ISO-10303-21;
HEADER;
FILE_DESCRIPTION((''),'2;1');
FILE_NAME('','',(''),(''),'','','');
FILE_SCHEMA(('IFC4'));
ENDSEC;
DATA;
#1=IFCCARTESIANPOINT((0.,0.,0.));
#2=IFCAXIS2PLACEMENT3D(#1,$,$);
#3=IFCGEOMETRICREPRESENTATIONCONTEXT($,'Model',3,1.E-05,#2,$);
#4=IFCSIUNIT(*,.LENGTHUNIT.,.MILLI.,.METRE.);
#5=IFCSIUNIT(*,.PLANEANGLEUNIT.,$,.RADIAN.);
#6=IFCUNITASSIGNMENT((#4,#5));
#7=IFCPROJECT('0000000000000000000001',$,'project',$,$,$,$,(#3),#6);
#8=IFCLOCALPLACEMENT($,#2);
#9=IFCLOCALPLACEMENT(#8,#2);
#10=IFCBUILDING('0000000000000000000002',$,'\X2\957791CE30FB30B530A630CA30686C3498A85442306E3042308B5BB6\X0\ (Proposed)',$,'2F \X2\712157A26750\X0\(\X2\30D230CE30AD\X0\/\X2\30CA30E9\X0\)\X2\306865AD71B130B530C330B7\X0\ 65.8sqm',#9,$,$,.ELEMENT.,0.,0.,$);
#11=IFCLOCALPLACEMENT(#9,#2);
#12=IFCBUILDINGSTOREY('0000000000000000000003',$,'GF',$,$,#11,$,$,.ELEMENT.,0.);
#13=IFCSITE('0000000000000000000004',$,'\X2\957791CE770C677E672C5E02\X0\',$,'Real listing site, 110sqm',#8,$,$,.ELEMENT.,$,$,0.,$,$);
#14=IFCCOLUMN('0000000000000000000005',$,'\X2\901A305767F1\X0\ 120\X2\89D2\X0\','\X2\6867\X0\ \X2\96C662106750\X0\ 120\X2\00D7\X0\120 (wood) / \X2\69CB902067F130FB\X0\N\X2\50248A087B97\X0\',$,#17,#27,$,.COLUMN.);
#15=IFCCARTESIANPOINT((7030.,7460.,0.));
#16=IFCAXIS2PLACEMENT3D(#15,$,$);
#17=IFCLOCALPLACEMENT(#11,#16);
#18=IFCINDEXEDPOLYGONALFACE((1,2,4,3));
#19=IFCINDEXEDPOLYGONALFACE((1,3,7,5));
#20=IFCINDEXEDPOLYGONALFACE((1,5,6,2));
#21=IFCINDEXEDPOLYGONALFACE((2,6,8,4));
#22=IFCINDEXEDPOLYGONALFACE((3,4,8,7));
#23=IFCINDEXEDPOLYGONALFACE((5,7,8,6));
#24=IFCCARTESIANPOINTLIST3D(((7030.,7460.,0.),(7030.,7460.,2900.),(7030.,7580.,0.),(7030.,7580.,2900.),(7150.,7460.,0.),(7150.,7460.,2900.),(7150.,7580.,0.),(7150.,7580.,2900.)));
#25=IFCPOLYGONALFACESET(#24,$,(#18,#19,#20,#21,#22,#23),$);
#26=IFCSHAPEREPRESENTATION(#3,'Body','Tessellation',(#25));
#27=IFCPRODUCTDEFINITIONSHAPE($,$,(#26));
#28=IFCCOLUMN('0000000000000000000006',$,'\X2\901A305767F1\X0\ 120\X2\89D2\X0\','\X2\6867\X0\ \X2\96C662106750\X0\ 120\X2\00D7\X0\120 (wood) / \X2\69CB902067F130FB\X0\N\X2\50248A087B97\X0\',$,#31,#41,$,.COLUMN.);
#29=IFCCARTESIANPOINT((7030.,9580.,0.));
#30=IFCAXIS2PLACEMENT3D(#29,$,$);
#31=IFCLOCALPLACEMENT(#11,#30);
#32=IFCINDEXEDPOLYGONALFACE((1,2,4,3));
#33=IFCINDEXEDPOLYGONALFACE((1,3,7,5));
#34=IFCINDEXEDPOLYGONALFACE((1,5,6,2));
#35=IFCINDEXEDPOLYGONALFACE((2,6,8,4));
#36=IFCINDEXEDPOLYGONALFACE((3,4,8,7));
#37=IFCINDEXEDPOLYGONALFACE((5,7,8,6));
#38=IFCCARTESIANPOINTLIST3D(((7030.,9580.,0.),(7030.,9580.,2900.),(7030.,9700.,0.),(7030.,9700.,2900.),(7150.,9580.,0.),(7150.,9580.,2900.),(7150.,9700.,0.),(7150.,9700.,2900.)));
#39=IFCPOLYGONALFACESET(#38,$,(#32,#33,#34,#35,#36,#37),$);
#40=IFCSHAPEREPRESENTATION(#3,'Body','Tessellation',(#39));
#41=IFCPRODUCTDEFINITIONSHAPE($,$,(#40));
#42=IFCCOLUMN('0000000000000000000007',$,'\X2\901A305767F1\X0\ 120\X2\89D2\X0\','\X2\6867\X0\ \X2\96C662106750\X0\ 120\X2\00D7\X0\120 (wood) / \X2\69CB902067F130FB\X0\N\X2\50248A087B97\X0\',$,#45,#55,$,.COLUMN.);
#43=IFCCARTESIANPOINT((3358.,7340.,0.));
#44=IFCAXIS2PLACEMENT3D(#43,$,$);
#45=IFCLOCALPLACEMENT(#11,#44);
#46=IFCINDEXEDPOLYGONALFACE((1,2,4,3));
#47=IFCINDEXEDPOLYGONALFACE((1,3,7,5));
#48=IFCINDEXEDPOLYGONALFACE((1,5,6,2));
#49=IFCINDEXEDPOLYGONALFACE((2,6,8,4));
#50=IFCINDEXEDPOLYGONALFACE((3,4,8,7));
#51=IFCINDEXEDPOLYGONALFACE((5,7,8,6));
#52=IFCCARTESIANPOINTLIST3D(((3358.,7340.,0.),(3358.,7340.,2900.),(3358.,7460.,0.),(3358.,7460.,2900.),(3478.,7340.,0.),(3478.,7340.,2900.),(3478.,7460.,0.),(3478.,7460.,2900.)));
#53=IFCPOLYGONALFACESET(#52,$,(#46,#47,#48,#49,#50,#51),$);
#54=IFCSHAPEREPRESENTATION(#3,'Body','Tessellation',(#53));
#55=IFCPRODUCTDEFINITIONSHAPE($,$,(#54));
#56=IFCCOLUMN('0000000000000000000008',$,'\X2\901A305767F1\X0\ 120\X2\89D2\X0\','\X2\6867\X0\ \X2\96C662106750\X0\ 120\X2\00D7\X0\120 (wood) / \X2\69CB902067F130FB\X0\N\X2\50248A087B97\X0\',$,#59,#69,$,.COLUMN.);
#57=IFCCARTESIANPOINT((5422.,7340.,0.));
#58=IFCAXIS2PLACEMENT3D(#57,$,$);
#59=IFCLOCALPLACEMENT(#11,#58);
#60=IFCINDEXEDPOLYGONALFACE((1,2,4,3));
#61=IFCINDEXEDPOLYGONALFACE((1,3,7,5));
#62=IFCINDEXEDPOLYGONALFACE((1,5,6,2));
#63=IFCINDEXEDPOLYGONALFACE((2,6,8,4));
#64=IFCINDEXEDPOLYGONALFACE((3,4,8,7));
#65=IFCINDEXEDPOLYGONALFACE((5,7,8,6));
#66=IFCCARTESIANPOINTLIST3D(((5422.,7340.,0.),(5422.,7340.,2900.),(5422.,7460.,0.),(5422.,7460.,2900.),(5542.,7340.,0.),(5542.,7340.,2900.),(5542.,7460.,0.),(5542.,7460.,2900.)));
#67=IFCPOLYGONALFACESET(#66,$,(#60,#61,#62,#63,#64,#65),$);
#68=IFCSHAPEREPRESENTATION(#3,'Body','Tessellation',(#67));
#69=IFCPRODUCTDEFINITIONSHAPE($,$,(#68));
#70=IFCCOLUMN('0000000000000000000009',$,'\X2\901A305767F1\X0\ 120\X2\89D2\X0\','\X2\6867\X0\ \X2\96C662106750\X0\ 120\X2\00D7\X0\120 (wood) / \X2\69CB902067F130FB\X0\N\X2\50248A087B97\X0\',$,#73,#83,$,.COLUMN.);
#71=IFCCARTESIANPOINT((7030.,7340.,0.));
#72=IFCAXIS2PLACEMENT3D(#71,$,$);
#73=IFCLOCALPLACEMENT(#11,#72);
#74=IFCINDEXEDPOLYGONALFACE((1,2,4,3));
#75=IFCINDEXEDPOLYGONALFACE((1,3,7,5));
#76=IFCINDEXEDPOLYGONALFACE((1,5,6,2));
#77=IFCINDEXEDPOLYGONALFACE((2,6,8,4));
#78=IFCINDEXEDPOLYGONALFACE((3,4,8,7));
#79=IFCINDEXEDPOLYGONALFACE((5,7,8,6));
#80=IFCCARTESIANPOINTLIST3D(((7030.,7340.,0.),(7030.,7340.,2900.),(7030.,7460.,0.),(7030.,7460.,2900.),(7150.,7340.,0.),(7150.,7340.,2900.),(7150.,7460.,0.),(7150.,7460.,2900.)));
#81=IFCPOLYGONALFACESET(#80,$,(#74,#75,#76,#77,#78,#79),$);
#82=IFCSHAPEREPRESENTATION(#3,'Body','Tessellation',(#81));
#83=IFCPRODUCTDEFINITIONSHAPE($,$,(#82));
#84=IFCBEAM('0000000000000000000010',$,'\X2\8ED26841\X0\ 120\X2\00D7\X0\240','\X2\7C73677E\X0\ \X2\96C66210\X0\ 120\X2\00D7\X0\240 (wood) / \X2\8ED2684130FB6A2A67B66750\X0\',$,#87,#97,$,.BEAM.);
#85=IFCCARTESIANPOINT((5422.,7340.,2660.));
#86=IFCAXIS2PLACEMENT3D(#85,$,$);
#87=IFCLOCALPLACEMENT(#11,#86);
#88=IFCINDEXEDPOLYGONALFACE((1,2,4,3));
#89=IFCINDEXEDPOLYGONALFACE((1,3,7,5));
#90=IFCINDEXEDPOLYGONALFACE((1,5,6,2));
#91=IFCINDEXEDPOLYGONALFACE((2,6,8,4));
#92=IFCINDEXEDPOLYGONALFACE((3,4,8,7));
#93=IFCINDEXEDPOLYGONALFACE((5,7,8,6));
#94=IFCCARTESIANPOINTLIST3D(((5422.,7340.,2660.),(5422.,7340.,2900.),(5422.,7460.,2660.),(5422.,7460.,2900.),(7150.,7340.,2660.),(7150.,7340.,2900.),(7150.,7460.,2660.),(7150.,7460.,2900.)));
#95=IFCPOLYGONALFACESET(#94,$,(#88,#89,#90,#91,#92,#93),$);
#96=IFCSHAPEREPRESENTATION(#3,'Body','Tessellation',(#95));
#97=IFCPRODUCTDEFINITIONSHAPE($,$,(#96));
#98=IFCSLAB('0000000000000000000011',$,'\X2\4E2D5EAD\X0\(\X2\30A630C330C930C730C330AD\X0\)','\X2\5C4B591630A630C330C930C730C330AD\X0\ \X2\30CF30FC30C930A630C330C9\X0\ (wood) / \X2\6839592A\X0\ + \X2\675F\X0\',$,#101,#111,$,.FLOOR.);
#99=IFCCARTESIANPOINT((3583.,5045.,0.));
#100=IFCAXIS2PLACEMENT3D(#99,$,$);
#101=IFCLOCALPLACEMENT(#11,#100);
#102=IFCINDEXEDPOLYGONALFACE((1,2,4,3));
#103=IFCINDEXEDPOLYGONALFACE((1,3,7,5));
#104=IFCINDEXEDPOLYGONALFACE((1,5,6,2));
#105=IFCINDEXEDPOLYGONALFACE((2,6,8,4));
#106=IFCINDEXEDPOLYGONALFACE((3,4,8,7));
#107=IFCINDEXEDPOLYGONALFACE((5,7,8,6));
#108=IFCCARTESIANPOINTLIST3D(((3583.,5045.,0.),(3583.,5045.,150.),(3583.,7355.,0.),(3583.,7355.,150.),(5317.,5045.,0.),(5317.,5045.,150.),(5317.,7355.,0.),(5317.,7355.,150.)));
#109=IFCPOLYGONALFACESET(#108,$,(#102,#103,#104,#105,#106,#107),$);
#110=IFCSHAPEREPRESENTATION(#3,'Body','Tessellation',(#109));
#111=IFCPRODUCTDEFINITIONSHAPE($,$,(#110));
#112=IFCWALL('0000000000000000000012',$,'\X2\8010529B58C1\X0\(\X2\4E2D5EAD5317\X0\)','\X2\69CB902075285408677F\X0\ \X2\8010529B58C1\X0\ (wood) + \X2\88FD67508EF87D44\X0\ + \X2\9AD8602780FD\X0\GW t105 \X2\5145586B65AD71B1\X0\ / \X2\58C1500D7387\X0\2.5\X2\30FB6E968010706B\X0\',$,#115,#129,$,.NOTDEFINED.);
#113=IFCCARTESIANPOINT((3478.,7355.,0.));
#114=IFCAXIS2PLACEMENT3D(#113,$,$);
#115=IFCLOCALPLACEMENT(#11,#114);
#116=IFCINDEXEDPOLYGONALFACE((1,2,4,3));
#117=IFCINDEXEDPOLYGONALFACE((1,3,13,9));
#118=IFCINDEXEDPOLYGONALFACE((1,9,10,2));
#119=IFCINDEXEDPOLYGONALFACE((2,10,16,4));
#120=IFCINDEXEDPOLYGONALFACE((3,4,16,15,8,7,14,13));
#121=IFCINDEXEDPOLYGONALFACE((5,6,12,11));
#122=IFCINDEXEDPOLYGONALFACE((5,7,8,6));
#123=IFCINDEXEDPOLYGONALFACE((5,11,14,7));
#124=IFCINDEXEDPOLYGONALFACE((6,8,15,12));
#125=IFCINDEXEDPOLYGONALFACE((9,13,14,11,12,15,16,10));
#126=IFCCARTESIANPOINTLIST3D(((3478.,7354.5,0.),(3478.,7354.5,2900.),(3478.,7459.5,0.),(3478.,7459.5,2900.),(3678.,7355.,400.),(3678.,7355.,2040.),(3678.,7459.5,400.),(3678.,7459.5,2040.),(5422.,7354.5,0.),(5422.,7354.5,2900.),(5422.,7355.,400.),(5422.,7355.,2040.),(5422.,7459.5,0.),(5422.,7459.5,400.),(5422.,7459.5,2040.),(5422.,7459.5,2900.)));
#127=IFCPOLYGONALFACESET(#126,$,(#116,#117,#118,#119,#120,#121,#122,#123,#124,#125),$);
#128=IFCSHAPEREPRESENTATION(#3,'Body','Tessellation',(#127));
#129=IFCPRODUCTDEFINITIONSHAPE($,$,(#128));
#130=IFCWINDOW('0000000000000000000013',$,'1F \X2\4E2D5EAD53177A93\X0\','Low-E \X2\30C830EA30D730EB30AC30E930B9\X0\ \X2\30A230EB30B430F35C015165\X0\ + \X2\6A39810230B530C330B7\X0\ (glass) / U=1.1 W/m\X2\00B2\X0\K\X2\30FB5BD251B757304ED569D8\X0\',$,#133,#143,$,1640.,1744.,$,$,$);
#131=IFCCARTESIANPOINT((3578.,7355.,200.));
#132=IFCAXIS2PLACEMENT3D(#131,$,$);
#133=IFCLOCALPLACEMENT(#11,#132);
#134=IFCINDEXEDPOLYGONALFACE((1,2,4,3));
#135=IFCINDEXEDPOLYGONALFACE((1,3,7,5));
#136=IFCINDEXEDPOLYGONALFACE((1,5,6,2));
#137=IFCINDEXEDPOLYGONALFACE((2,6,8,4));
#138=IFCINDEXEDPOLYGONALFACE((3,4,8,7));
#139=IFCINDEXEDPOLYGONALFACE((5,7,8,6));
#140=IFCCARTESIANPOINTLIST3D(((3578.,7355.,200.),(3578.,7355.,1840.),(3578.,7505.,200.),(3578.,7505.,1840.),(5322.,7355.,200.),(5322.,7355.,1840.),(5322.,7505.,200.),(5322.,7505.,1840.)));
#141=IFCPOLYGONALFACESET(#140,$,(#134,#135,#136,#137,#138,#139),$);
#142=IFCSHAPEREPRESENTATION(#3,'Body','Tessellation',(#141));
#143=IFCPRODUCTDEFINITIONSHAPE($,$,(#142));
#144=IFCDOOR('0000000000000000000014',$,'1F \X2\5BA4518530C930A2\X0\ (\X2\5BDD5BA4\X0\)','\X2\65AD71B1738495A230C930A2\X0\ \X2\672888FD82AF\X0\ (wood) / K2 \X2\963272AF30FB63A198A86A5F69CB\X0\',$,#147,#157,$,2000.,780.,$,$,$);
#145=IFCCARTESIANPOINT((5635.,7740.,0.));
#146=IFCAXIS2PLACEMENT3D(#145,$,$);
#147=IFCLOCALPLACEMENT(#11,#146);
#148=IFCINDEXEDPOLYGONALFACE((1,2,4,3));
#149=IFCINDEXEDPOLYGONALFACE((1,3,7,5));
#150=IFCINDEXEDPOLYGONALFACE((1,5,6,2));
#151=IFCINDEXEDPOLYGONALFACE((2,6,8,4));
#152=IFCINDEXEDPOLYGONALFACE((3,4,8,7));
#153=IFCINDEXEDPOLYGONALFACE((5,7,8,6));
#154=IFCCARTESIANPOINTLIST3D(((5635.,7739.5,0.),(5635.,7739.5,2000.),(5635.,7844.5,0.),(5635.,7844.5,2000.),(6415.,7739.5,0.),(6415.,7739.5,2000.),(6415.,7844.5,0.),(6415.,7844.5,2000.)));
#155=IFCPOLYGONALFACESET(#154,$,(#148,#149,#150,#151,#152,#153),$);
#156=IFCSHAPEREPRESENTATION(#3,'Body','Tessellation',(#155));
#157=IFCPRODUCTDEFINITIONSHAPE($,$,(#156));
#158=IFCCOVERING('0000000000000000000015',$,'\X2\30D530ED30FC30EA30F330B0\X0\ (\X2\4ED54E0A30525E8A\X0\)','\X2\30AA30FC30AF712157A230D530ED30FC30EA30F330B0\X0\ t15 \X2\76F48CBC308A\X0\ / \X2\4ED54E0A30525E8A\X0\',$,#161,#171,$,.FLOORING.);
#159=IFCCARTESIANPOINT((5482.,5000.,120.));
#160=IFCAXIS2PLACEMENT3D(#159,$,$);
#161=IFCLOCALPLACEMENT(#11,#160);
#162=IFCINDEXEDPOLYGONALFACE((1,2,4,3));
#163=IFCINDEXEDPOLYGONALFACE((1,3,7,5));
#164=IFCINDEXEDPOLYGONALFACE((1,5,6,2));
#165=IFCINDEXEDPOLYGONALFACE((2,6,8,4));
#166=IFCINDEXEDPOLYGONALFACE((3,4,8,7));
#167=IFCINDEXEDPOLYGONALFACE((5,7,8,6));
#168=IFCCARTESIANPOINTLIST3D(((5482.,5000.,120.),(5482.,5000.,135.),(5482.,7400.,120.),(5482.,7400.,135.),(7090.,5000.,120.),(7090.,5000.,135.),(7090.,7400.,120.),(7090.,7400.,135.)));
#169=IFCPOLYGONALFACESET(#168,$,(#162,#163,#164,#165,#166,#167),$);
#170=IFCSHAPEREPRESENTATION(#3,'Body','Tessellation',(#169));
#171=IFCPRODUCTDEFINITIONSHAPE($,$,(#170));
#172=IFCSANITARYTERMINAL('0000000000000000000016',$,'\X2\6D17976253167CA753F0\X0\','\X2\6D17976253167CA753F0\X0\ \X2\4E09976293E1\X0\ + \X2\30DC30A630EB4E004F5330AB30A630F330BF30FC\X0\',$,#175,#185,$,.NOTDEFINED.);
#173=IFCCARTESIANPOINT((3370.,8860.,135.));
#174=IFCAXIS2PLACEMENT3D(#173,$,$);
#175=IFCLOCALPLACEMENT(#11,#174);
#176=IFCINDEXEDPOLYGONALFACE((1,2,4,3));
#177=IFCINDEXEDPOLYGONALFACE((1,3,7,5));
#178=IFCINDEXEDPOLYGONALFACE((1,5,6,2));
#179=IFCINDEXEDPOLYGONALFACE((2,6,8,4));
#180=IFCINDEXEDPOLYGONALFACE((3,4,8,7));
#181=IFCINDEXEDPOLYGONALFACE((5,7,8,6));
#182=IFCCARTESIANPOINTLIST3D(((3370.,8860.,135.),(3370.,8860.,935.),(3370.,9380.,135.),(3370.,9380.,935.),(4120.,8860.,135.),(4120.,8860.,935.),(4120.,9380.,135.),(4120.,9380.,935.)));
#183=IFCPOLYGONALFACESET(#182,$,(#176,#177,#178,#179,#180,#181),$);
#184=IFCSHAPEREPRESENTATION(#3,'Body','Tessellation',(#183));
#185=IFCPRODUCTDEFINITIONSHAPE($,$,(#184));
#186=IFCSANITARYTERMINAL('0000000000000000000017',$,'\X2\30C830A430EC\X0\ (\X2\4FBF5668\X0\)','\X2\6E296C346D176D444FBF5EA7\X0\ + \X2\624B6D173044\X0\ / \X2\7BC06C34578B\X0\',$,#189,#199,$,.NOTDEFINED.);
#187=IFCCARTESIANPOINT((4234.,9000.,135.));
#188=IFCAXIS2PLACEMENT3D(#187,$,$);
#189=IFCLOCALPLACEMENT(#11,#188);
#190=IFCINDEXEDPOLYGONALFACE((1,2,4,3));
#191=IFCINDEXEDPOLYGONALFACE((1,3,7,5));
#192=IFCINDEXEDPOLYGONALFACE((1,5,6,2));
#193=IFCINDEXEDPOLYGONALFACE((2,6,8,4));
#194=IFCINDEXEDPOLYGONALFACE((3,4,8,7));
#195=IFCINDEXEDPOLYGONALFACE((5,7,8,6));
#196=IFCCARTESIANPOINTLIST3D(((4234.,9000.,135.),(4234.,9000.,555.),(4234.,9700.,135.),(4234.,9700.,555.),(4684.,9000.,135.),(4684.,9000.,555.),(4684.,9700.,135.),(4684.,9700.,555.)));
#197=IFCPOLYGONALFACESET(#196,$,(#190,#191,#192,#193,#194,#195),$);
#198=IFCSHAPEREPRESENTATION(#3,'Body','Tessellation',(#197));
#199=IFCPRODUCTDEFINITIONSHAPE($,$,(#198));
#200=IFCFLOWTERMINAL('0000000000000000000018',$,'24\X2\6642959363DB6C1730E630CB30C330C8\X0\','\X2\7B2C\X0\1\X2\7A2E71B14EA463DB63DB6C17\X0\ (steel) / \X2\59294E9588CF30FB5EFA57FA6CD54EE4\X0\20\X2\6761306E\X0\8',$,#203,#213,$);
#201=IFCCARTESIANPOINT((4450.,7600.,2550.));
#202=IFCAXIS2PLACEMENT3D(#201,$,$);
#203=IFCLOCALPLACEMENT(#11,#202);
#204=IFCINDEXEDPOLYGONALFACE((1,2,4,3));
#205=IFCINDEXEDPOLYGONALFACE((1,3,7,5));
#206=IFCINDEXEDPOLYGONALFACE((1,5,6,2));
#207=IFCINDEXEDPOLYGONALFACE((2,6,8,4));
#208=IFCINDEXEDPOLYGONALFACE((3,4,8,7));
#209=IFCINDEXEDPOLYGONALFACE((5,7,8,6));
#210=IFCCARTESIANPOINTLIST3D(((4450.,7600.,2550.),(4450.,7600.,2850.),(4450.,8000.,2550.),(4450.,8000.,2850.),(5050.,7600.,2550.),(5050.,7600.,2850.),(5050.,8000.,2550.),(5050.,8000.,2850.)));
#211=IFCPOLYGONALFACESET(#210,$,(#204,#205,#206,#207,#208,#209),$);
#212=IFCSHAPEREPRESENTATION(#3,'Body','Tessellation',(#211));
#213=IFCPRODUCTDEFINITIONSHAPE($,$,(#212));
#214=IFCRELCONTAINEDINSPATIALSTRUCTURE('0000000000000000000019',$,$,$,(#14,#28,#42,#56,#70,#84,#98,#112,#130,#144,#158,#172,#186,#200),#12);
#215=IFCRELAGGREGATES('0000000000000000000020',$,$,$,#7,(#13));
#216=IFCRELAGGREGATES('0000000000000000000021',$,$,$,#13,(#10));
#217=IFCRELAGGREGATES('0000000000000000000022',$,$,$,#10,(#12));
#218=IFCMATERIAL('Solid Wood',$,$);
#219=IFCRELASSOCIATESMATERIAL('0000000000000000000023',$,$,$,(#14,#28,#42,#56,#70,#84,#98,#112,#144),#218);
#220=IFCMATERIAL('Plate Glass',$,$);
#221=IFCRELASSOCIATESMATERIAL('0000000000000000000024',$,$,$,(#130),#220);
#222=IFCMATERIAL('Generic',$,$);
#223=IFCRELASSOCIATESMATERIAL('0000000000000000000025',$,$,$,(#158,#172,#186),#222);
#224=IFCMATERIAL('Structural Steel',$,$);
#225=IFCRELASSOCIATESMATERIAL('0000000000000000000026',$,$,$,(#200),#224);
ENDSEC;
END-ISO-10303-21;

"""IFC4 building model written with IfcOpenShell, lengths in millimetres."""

from ifc_helpers import new_model, si_unit, frame, frame_2d, origin, place, context, project, spatial, rectangle, extrude, material, element, fill, save


model = new_model("IFC4")

# Units and contexts
model_context = context("Model", 3, precision=1e-05, world=origin())
ifc_project = project(units=[si_unit("LENGTHUNIT", "METRE", prefix="MILLI"), si_unit("PLANEANGLEUNIT", "RADIAN")], contexts=[model_context])

# Site, building, storey
site_placement = place(None, origin())
site = spatial("IfcSite", under=ifc_project, at=site_placement, Name="長野県松本市", ObjectType="Real listing site, 110sqm", CompositionType="ELEMENT", RefElevation=0.0)
building_placement = place(site_placement, origin())
building = spatial("IfcBuilding", under=site, at=building_placement, Name="長野・サウナと水風呂のある家 (Proposed)", ObjectType="2F 無垢材(ヒノキ/ナラ)と断熱サッシ 65.8sqm", CompositionType="ELEMENT", ElevationOfRefHeight=0.0, ElevationOfTerrain=0.0)
storey_placement = place(building_placement, origin())
storey = spatial("IfcBuildingStorey", under=building, at=storey_placement, Name="GF", CompositionType="ELEMENT", Elevation=0.0)

# Columns
ifc_material_1 = material(Name="Solid Wood")
column_1_placement = place(storey_placement, frame((7030.0, 7460.0, 0.0)))
element("IfcColumn", 1, at=column_1_placement, inside=storey, material=ifc_material_1, Name="通し柱 120角", Description="桧 集成材 120×120 (wood) / 構造柱・N値計算", PredefinedType="COLUMN", context=model_context, shape_type="SweptSolid", body=[
    extrude(rectangle(XDim=120.0, YDim=120.0, at=frame_2d((60.0, 60.0))), frame((7030.0, 7460.0, 0.0)), (0.0, 0.0, 1.0), 2900.0),
])
column_2_placement = place(storey_placement, frame((7030.0, 9580.0, 0.0)))
element("IfcColumn", 2, at=column_2_placement, inside=storey, material=ifc_material_1, Name="通し柱 120角", Description="桧 集成材 120×120 (wood) / 構造柱・N値計算", PredefinedType="COLUMN", context=model_context, shape_type="SweptSolid", body=[
    extrude(rectangle(XDim=120.0, YDim=120.0, at=frame_2d((60.0, 60.0))), frame((7030.0, 9580.0, 0.0)), (0.0, 0.0, 1.0), 2900.0),
])
column_3_placement = place(storey_placement, frame((3358.0, 7340.0, 0.0)))
element("IfcColumn", 3, at=column_3_placement, inside=storey, material=ifc_material_1, Name="通し柱 120角", Description="桧 集成材 120×120 (wood) / 構造柱・N値計算", PredefinedType="COLUMN", context=model_context, shape_type="SweptSolid", body=[
    extrude(rectangle(XDim=120.0, YDim=120.0, at=frame_2d((60.0, 60.0))), frame((3358.0, 7340.0, 0.0)), (0.0, 0.0, 1.0), 2900.0),
])
column_4_placement = place(storey_placement, frame((5422.0, 7340.0, 0.0)))
element("IfcColumn", 4, at=column_4_placement, inside=storey, material=ifc_material_1, Name="通し柱 120角", Description="桧 集成材 120×120 (wood) / 構造柱・N値計算", PredefinedType="COLUMN", context=model_context, shape_type="SweptSolid", body=[
    extrude(rectangle(XDim=120.0, YDim=120.0, at=frame_2d((60.0, 60.0))), frame((5422.0, 7340.0, 0.0)), (0.0, 0.0, 1.0), 2900.0),
])
column_5_placement = place(storey_placement, frame((7030.0, 7340.0, 0.0)))
element("IfcColumn", 5, at=column_5_placement, inside=storey, material=ifc_material_1, Name="通し柱 120角", Description="桧 集成材 120×120 (wood) / 構造柱・N値計算", PredefinedType="COLUMN", context=model_context, shape_type="SweptSolid", body=[
    extrude(rectangle(XDim=120.0, YDim=120.0, at=frame_2d((60.0, 60.0))), frame((7030.0, 7340.0, 0.0)), (0.0, 0.0, 1.0), 2900.0),
])

# Beam
beam_1_placement = place(storey_placement, frame((5422.0, 7340.0, 2660.0)))
element("IfcBeam", 6, at=beam_1_placement, inside=storey, material=ifc_material_1, Name="軒桁 120×240", Description="米松 集成 120×240 (wood) / 軒桁・横架材", PredefinedType="BEAM", context=model_context, shape_type="SweptSolid", body=[
    extrude(rectangle(XDim=1728.0, YDim=120.0, at=frame_2d((864.0, 60.0))), frame((5422.0, 7340.0, 2660.0)), (0.0, 0.0, 1.0), 240.0),
])

# Slab
slab_placement = place(storey_placement, frame((3583.0, 5045.0, 0.0)))
element("IfcSlab", 7, at=slab_placement, inside=storey, material=ifc_material_1, Name="中庭(ウッドデッキ)", Description="屋外ウッドデッキ ハードウッド (wood) / 根太 + 束", PredefinedType="FLOOR", context=model_context, shape_type="SweptSolid", body=[
    extrude(rectangle(XDim=1734.0, YDim=2310.0, at=frame_2d((867.0, 1155.0))), frame((3583.0, 5045.0, 0.0)), (0.0, 0.0, 1.0), 150.0),
])

# Wall, opening, window
wall_1_placement = place(storey_placement, frame((3478.0, 7355.0, 0.0)))
wall_1 = element("IfcWall", 8, at=wall_1_placement, inside=storey, material=ifc_material_1, Name="耐力壁(中庭北)", Description="構造用合板 耐力壁 (wood) + 製材軸組 + 高性能GW t105 充填断熱 / 壁倍率2.5・準耐火", PredefinedType="NOTDEFINED", context=model_context, shape_type="SweptSolid", body=[
    extrude(rectangle(XDim=1944.0, YDim=105.0, at=frame_2d((972.0, 52.0))), frame((3478.0, 7355.0, 0.0)), (0.0, 0.0, 1.0), 2900.0),
])
opening_placement = place(storey_placement, frame((3578.0, 7355.0, 200.0)))
opening = element("IfcOpeningElement", 9, at=opening_placement, cuts=wall_1, PredefinedType="NOTDEFINED", context=model_context, shape_type="SweptSolid", body=[
    extrude(rectangle(XDim=1744.0, YDim=150.0, at=frame_2d((872.0, 75.0))), frame((3578.0, 7355.0, 200.0)), (0.0, 0.0, 1.0), 1640.0),
])
ifc_material_2 = material(Name="Plate Glass")
window_placement = place(storey_placement, frame((3578.0, 7355.0, 200.0)))
window = element("IfcWindow", 10, at=window_placement, inside=storey, material=ifc_material_2, Name="1F 中庭北窓", Description="Low-E トリプルガラス アルゴン封入 + 樹脂サッシ (glass) / U=1.1 W/m²K・寒冷地仕様", OverallHeight=1640.0, OverallWidth=1744.0, context=model_context, shape_type="SweptSolid", body=[
    extrude(rectangle(XDim=1744.0, YDim=150.0, at=frame_2d((872.0, 75.0))), frame((3578.0, 7355.0, 200.0)), (0.0, 0.0, 1.0), 1640.0),
])
fill(opening, window)

# Door
door_placement = place(storey_placement, frame((5635.0, 7740.0, 0.0)))
element("IfcDoor", 11, at=door_placement, inside=storey, material=ifc_material_1, Name="1F 室内ドア (寝室)", Description="断熱玄関ドア 木製芯 (wood) / K2 防犯・採風機構", OverallHeight=2000.0, OverallWidth=780.0, context=model_context, shape_type="SweptSolid", body=[
    extrude(rectangle(XDim=780.0, YDim=105.0, at=frame_2d((390.0, 52.0))), frame((5635.0, 7740.0, 0.0)), (0.0, 0.0, 1.0), 2000.0),
])

# Covering
ifc_material_3 = material(Name="Generic")
covering_placement = place(storey_placement, frame((5482.0, 5000.0, 120.0)))
element("IfcCovering", 12, at=covering_placement, inside=storey, material=ifc_material_3, Name="フローリング (仕上げ床)", Description="オーク無垢フローリング t15 直貼り / 仕上げ床", PredefinedType="FLOORING", context=model_context, shape_type="SweptSolid", body=[
    extrude(rectangle(XDim=1608.0, YDim=2400.0, at=frame_2d((804.0, 1200.0))), frame((5482.0, 5000.0, 120.0)), (0.0, 0.0, 1.0), 15.0),
])

# Sanitary terminals
sanitary_terminal_1_placement = place(storey_placement, frame((3370.0, 8860.0, 135.0)))
element("IfcSanitaryTerminal", 13, at=sanitary_terminal_1_placement, inside=storey, material=ifc_material_3, Name="洗面化粧台", Description="洗面化粧台 三面鏡 + ボウル一体カウンター", PredefinedType="NOTDEFINED", context=model_context, shape_type="SweptSolid", body=[
    extrude(rectangle(XDim=750.0, YDim=520.0, at=frame_2d((375.0, 260.0))), frame((3370.0, 8860.0, 135.0)), (0.0, 0.0, 1.0), 800.0),
])
sanitary_terminal_2_placement = place(storey_placement, frame((4234.0, 9000.0, 135.0)))
element("IfcSanitaryTerminal", 14, at=sanitary_terminal_2_placement, inside=storey, material=ifc_material_3, Name="トイレ (便器)", Description="温水洗浄便座 + 手洗い / 節水型", PredefinedType="NOTDEFINED", context=model_context, shape_type="SweptSolid", body=[
    extrude(rectangle(XDim=450.0, YDim=700.0, at=frame_2d((225.0, 350.0))), frame((4234.0, 9000.0, 135.0)), (0.0, 0.0, 1.0), 420.0),
])

# Flow terminal
ifc_material_4 = material(Name="Structural Steel")
flow_terminal_placement = place(storey_placement, frame((4450.0, 7600.0, 2550.0)))
element("IfcFlowTerminal", 15, at=flow_terminal_placement, inside=storey, material=ifc_material_4, Name="24時間換気ユニット", Description="第1種熱交換換気 (steel) / 天井裏・建基法令20条の8", context=model_context, shape_type="SweptSolid", body=[
    extrude(rectangle(XDim=600.0, YDim=400.0, at=frame_2d((300.0, 200.0))), frame((4450.0, 7600.0, 2550.0)), (0.0, 0.0, 1.0), 300.0),
])

save(model, "model.ifc")
